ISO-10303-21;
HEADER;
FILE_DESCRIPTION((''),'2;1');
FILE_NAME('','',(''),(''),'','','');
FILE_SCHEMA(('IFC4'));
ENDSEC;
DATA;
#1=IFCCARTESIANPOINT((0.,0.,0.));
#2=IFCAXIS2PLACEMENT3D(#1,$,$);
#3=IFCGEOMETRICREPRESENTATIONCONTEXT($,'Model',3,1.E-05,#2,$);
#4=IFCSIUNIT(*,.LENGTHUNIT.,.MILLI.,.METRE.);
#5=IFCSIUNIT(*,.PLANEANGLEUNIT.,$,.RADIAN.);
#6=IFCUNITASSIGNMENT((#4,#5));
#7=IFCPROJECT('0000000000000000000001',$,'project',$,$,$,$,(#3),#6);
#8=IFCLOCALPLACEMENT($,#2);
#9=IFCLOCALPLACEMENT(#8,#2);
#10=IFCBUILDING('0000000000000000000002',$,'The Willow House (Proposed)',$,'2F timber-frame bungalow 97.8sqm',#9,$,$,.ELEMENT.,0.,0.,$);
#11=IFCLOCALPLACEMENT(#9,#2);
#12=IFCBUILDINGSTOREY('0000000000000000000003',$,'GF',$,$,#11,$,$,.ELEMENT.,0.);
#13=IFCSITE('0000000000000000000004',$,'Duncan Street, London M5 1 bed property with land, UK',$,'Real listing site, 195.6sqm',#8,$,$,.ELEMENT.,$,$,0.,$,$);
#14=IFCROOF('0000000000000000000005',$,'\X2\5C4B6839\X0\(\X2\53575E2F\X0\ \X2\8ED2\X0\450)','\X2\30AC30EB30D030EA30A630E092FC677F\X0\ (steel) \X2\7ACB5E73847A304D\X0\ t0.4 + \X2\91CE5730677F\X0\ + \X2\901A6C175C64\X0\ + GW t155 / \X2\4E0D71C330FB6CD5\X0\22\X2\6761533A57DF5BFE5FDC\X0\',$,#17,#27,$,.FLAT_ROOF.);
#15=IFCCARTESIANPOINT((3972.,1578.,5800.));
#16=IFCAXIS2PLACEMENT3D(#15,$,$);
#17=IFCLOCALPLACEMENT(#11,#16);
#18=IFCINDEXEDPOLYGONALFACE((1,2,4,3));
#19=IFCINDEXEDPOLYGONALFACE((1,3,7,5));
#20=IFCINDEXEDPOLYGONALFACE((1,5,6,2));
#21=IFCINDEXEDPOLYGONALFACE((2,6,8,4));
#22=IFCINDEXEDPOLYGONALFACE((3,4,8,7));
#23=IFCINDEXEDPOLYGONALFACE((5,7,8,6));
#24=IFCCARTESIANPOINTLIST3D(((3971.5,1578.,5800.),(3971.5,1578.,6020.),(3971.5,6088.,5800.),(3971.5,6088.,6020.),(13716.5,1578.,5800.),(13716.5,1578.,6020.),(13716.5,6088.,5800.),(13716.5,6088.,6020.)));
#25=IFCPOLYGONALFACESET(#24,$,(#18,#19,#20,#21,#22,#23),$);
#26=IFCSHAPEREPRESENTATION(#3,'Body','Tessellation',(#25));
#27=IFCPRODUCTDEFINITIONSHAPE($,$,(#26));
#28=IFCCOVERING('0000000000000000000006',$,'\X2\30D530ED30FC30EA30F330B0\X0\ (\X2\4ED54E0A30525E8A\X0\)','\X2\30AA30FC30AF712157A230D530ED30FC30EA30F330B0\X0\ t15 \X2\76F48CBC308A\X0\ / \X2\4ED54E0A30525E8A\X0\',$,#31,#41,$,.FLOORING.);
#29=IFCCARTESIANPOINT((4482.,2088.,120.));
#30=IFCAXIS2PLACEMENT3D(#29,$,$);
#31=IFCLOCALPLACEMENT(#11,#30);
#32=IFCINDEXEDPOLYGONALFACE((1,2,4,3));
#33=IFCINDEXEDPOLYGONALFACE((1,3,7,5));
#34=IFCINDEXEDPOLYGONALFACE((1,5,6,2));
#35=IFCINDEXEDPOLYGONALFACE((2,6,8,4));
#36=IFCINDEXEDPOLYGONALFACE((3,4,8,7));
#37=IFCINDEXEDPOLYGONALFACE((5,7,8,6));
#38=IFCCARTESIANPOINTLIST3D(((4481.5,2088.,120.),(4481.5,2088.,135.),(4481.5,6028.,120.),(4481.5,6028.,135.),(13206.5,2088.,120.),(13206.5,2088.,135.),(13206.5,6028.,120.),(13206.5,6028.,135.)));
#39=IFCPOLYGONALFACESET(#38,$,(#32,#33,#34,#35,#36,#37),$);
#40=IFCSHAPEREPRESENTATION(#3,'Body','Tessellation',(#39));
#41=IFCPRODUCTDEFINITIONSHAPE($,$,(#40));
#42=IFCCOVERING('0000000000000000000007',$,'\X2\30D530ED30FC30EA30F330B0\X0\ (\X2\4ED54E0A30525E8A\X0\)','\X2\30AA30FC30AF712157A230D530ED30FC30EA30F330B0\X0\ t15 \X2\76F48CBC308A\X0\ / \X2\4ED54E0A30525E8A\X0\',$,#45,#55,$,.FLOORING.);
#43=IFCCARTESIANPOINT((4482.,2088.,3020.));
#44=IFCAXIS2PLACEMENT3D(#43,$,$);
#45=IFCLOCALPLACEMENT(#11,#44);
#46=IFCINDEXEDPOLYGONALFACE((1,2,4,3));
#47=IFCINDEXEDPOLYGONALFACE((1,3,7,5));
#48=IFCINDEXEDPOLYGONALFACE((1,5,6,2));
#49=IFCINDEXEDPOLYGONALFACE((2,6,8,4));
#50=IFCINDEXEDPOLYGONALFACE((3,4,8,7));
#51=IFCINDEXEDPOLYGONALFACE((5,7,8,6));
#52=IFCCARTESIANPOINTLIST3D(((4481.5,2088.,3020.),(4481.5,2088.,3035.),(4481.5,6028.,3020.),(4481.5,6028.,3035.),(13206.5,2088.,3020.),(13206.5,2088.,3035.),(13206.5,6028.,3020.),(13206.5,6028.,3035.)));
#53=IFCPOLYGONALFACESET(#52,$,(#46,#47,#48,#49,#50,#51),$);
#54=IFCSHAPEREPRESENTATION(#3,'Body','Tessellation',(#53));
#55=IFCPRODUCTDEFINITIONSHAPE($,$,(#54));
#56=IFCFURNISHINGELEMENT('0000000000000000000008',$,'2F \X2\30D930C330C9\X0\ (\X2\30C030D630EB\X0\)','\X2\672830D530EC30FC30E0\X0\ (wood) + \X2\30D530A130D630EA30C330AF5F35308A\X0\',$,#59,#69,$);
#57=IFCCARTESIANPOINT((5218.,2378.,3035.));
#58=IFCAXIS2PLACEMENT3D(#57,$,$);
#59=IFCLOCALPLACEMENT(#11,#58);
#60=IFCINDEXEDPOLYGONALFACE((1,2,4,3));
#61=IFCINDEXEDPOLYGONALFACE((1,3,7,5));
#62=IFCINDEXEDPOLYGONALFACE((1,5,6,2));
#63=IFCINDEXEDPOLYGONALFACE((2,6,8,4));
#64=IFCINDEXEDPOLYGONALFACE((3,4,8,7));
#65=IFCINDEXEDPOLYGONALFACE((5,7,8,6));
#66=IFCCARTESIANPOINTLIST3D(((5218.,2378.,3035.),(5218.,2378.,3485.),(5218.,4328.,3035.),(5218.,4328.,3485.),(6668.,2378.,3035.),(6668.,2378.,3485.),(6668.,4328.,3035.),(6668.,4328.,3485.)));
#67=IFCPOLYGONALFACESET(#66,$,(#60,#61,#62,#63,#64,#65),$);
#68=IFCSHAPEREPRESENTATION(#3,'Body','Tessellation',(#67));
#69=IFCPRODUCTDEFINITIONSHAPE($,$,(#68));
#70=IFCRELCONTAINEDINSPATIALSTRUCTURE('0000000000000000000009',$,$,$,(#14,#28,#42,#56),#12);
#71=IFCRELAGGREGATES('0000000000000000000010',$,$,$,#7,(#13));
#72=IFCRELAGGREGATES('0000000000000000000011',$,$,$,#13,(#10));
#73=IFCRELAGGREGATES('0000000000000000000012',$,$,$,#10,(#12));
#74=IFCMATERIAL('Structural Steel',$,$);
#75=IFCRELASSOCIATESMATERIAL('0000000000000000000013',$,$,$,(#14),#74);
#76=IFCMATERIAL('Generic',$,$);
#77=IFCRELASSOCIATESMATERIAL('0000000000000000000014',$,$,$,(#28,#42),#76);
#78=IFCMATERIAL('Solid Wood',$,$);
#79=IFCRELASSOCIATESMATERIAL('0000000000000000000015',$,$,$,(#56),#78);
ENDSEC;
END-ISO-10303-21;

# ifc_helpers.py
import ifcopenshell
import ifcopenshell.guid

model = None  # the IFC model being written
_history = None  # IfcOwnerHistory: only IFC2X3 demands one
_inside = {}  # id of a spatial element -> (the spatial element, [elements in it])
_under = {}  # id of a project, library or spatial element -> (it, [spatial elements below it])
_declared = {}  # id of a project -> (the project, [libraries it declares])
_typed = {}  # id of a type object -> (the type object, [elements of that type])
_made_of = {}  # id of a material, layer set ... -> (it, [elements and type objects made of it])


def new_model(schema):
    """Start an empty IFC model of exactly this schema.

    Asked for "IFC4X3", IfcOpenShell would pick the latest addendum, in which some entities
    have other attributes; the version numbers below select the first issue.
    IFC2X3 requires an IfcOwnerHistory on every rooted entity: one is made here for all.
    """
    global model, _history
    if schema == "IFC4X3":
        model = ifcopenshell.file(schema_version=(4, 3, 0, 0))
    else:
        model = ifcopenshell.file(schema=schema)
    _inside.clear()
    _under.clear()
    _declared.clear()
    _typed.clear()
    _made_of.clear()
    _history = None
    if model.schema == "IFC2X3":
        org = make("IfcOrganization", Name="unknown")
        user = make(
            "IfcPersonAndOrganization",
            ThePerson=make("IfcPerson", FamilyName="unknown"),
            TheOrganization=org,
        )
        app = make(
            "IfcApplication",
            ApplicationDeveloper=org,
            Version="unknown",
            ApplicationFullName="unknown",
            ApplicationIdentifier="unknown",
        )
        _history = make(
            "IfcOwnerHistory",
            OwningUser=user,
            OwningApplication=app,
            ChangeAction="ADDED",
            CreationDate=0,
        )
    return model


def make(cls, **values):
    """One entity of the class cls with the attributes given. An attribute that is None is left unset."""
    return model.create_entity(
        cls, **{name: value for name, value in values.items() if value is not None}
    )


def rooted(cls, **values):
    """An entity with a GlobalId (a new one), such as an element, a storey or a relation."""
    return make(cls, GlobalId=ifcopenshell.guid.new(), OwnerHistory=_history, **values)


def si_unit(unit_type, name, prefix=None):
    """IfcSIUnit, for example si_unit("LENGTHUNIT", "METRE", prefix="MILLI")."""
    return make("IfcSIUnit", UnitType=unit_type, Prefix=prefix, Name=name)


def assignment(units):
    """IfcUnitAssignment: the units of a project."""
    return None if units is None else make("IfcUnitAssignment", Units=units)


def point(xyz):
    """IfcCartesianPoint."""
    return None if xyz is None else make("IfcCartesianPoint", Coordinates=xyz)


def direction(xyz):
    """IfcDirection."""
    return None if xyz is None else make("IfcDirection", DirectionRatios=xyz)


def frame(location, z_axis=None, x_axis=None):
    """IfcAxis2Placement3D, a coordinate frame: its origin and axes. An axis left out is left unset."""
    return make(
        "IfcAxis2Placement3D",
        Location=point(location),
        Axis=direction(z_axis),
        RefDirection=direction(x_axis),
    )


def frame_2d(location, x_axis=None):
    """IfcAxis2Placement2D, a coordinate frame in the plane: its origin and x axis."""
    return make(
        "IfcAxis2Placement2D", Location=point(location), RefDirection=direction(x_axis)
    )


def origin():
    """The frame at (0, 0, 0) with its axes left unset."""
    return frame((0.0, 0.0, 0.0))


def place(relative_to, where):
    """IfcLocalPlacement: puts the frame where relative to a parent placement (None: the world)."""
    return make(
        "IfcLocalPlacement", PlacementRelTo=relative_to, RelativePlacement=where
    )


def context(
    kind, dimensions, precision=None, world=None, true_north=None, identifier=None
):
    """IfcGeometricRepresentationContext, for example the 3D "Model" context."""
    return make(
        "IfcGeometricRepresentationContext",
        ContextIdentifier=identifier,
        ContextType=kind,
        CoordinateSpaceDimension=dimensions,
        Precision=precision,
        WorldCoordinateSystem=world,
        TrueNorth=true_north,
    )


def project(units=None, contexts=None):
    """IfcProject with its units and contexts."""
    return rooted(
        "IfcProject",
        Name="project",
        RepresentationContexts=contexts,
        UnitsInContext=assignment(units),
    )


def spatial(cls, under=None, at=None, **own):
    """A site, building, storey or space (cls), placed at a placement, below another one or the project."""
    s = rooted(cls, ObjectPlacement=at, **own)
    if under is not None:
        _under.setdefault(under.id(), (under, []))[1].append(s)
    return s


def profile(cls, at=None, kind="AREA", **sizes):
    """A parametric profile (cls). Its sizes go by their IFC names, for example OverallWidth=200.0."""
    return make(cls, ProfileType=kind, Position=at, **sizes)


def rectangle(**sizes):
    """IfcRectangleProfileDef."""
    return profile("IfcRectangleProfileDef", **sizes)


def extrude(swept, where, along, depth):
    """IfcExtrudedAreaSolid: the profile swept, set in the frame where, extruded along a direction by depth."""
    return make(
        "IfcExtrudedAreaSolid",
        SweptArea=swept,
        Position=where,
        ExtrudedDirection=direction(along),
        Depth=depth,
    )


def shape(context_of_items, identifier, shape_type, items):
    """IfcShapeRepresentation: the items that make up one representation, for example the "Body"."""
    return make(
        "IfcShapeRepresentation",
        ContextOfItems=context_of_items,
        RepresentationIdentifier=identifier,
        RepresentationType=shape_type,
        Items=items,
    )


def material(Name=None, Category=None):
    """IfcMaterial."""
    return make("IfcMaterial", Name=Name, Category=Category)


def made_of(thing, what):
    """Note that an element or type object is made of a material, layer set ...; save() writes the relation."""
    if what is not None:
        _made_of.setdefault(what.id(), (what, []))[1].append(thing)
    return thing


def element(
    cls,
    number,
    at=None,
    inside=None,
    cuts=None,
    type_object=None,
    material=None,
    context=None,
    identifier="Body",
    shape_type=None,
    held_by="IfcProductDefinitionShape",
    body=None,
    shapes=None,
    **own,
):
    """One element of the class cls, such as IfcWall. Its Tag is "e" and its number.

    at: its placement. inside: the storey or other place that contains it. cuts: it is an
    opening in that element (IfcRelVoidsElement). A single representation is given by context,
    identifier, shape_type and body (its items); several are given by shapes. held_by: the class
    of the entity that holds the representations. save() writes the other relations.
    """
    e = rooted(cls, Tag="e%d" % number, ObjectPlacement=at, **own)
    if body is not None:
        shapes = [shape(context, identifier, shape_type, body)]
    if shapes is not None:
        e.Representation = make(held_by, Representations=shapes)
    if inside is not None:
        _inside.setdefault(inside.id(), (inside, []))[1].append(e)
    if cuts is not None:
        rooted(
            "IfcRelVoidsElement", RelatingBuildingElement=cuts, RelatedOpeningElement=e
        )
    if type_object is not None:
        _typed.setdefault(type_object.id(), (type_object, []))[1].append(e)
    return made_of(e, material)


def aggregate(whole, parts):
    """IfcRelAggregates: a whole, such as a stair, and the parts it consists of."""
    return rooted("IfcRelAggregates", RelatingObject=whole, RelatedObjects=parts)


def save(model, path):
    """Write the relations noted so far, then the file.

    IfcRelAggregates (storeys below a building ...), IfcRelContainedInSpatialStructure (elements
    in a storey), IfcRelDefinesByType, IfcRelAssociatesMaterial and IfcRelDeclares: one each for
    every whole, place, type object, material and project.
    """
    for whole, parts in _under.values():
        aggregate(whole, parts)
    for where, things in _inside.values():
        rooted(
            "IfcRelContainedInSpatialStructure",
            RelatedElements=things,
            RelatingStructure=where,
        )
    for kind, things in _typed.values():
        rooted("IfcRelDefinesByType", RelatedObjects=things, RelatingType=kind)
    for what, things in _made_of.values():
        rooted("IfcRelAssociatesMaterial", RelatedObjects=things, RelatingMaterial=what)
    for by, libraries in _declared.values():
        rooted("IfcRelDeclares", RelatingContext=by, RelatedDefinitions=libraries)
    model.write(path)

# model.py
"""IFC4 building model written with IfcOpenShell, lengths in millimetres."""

from ifc_helpers import new_model, si_unit, frame, frame_2d, origin, place, context, project, spatial, rectangle, extrude, material, element, save


model = new_model("IFC4")

# Units and contexts
model_context = context("Model", 3, precision=1e-05, world=origin())
ifc_project = project(units=[si_unit("LENGTHUNIT", "METRE", prefix="MILLI"), si_unit("PLANEANGLEUNIT", "RADIAN")], contexts=[model_context])

# Site, building, storey
site_placement = place(None, origin())
site = spatial("IfcSite", under=ifc_project, at=site_placement, Name="Duncan Street, London M5 1 bed property with land, UK", ObjectType="Real listing site, 195.6sqm", CompositionType="ELEMENT", RefElevation=0.0)
building_placement = place(site_placement, origin())
building = spatial("IfcBuilding", under=site, at=building_placement, Name="The Willow House (Proposed)", ObjectType="2F timber-frame bungalow 97.8sqm", CompositionType="ELEMENT", ElevationOfRefHeight=0.0, ElevationOfTerrain=0.0)
storey_placement = place(building_placement, origin())
storey = spatial("IfcBuildingStorey", under=building, at=storey_placement, Name="GF", CompositionType="ELEMENT", Elevation=0.0)

# Shared definitions
ifc_material_1 = material(Name="Solid Wood")

# Roof
ifc_material_2 = material(Name="Structural Steel")
for number, where, name in (
    (1, (3972.0, 1578.0, 5800.0), "屋根(南帯 軒450)"),
):
    element("IfcRoof", number, at=place(storey_placement, frame(where)), inside=storey, material=ifc_material_2, Name=name, Description="ガルバリウム鋼板 (steel) 立平葺き t0.4 + 野地板 + 通気層 + GW t155 / 不燃・法22条区域対応", PredefinedType="FLAT_ROOF", context=model_context, shape_type="SweptSolid", body=[
        extrude(rectangle(XDim=9745.0, YDim=4510.0, at=frame_2d((4872.0, 2255.0))), frame((3972.0, 1578.0, 5800.0)), (0.0, 0.0, 1.0), 220.0),
    ])

# Coverings
ifc_material_3 = material(Name="Generic")
covering_1_placement = place(storey_placement, frame((4482.0, 2088.0, 120.0)))
element("IfcCovering", 2, at=covering_1_placement, inside=storey, material=ifc_material_3, Name="フローリング (仕上げ床)", Description="オーク無垢フローリング t15 直貼り / 仕上げ床", PredefinedType="FLOORING", context=model_context, shape_type="SweptSolid", body=[
    extrude(rectangle(XDim=8725.0, YDim=3940.0, at=frame_2d((4362.0, 1970.0))), frame((4482.0, 2088.0, 120.0)), (0.0, 0.0, 1.0), 15.0),
])
covering_2_placement = place(storey_placement, frame((4482.0, 2088.0, 3020.0)))
element("IfcCovering", 3, at=covering_2_placement, inside=storey, material=ifc_material_3, Name="フローリング (仕上げ床)", Description="オーク無垢フローリング t15 直貼り / 仕上げ床", PredefinedType="FLOORING", context=model_context, shape_type="SweptSolid", body=[
    extrude(rectangle(XDim=8725.0, YDim=3940.0, at=frame_2d((4362.0, 1970.0))), frame((4482.0, 2088.0, 3020.0)), (0.0, 0.0, 1.0), 15.0),
])

# Furnishing element
furnishing_placement = place(storey_placement, frame((5218.0, 2378.0, 3035.0)))
element("IfcFurnishingElement", 4, at=furnishing_placement, inside=storey, material=ifc_material_1, Name="2F ベッド (ダブル)", Description="木フレーム (wood) + ファブリック張り", context=model_context, shape_type="SweptSolid", body=[
    extrude(rectangle(XDim=1450.0, YDim=1950.0, at=frame_2d((725.0, 975.0))), frame((5218.0, 2378.0, 3035.0)), (0.0, 0.0, 1.0), 450.0),
])

save(model, "model.ifc")
